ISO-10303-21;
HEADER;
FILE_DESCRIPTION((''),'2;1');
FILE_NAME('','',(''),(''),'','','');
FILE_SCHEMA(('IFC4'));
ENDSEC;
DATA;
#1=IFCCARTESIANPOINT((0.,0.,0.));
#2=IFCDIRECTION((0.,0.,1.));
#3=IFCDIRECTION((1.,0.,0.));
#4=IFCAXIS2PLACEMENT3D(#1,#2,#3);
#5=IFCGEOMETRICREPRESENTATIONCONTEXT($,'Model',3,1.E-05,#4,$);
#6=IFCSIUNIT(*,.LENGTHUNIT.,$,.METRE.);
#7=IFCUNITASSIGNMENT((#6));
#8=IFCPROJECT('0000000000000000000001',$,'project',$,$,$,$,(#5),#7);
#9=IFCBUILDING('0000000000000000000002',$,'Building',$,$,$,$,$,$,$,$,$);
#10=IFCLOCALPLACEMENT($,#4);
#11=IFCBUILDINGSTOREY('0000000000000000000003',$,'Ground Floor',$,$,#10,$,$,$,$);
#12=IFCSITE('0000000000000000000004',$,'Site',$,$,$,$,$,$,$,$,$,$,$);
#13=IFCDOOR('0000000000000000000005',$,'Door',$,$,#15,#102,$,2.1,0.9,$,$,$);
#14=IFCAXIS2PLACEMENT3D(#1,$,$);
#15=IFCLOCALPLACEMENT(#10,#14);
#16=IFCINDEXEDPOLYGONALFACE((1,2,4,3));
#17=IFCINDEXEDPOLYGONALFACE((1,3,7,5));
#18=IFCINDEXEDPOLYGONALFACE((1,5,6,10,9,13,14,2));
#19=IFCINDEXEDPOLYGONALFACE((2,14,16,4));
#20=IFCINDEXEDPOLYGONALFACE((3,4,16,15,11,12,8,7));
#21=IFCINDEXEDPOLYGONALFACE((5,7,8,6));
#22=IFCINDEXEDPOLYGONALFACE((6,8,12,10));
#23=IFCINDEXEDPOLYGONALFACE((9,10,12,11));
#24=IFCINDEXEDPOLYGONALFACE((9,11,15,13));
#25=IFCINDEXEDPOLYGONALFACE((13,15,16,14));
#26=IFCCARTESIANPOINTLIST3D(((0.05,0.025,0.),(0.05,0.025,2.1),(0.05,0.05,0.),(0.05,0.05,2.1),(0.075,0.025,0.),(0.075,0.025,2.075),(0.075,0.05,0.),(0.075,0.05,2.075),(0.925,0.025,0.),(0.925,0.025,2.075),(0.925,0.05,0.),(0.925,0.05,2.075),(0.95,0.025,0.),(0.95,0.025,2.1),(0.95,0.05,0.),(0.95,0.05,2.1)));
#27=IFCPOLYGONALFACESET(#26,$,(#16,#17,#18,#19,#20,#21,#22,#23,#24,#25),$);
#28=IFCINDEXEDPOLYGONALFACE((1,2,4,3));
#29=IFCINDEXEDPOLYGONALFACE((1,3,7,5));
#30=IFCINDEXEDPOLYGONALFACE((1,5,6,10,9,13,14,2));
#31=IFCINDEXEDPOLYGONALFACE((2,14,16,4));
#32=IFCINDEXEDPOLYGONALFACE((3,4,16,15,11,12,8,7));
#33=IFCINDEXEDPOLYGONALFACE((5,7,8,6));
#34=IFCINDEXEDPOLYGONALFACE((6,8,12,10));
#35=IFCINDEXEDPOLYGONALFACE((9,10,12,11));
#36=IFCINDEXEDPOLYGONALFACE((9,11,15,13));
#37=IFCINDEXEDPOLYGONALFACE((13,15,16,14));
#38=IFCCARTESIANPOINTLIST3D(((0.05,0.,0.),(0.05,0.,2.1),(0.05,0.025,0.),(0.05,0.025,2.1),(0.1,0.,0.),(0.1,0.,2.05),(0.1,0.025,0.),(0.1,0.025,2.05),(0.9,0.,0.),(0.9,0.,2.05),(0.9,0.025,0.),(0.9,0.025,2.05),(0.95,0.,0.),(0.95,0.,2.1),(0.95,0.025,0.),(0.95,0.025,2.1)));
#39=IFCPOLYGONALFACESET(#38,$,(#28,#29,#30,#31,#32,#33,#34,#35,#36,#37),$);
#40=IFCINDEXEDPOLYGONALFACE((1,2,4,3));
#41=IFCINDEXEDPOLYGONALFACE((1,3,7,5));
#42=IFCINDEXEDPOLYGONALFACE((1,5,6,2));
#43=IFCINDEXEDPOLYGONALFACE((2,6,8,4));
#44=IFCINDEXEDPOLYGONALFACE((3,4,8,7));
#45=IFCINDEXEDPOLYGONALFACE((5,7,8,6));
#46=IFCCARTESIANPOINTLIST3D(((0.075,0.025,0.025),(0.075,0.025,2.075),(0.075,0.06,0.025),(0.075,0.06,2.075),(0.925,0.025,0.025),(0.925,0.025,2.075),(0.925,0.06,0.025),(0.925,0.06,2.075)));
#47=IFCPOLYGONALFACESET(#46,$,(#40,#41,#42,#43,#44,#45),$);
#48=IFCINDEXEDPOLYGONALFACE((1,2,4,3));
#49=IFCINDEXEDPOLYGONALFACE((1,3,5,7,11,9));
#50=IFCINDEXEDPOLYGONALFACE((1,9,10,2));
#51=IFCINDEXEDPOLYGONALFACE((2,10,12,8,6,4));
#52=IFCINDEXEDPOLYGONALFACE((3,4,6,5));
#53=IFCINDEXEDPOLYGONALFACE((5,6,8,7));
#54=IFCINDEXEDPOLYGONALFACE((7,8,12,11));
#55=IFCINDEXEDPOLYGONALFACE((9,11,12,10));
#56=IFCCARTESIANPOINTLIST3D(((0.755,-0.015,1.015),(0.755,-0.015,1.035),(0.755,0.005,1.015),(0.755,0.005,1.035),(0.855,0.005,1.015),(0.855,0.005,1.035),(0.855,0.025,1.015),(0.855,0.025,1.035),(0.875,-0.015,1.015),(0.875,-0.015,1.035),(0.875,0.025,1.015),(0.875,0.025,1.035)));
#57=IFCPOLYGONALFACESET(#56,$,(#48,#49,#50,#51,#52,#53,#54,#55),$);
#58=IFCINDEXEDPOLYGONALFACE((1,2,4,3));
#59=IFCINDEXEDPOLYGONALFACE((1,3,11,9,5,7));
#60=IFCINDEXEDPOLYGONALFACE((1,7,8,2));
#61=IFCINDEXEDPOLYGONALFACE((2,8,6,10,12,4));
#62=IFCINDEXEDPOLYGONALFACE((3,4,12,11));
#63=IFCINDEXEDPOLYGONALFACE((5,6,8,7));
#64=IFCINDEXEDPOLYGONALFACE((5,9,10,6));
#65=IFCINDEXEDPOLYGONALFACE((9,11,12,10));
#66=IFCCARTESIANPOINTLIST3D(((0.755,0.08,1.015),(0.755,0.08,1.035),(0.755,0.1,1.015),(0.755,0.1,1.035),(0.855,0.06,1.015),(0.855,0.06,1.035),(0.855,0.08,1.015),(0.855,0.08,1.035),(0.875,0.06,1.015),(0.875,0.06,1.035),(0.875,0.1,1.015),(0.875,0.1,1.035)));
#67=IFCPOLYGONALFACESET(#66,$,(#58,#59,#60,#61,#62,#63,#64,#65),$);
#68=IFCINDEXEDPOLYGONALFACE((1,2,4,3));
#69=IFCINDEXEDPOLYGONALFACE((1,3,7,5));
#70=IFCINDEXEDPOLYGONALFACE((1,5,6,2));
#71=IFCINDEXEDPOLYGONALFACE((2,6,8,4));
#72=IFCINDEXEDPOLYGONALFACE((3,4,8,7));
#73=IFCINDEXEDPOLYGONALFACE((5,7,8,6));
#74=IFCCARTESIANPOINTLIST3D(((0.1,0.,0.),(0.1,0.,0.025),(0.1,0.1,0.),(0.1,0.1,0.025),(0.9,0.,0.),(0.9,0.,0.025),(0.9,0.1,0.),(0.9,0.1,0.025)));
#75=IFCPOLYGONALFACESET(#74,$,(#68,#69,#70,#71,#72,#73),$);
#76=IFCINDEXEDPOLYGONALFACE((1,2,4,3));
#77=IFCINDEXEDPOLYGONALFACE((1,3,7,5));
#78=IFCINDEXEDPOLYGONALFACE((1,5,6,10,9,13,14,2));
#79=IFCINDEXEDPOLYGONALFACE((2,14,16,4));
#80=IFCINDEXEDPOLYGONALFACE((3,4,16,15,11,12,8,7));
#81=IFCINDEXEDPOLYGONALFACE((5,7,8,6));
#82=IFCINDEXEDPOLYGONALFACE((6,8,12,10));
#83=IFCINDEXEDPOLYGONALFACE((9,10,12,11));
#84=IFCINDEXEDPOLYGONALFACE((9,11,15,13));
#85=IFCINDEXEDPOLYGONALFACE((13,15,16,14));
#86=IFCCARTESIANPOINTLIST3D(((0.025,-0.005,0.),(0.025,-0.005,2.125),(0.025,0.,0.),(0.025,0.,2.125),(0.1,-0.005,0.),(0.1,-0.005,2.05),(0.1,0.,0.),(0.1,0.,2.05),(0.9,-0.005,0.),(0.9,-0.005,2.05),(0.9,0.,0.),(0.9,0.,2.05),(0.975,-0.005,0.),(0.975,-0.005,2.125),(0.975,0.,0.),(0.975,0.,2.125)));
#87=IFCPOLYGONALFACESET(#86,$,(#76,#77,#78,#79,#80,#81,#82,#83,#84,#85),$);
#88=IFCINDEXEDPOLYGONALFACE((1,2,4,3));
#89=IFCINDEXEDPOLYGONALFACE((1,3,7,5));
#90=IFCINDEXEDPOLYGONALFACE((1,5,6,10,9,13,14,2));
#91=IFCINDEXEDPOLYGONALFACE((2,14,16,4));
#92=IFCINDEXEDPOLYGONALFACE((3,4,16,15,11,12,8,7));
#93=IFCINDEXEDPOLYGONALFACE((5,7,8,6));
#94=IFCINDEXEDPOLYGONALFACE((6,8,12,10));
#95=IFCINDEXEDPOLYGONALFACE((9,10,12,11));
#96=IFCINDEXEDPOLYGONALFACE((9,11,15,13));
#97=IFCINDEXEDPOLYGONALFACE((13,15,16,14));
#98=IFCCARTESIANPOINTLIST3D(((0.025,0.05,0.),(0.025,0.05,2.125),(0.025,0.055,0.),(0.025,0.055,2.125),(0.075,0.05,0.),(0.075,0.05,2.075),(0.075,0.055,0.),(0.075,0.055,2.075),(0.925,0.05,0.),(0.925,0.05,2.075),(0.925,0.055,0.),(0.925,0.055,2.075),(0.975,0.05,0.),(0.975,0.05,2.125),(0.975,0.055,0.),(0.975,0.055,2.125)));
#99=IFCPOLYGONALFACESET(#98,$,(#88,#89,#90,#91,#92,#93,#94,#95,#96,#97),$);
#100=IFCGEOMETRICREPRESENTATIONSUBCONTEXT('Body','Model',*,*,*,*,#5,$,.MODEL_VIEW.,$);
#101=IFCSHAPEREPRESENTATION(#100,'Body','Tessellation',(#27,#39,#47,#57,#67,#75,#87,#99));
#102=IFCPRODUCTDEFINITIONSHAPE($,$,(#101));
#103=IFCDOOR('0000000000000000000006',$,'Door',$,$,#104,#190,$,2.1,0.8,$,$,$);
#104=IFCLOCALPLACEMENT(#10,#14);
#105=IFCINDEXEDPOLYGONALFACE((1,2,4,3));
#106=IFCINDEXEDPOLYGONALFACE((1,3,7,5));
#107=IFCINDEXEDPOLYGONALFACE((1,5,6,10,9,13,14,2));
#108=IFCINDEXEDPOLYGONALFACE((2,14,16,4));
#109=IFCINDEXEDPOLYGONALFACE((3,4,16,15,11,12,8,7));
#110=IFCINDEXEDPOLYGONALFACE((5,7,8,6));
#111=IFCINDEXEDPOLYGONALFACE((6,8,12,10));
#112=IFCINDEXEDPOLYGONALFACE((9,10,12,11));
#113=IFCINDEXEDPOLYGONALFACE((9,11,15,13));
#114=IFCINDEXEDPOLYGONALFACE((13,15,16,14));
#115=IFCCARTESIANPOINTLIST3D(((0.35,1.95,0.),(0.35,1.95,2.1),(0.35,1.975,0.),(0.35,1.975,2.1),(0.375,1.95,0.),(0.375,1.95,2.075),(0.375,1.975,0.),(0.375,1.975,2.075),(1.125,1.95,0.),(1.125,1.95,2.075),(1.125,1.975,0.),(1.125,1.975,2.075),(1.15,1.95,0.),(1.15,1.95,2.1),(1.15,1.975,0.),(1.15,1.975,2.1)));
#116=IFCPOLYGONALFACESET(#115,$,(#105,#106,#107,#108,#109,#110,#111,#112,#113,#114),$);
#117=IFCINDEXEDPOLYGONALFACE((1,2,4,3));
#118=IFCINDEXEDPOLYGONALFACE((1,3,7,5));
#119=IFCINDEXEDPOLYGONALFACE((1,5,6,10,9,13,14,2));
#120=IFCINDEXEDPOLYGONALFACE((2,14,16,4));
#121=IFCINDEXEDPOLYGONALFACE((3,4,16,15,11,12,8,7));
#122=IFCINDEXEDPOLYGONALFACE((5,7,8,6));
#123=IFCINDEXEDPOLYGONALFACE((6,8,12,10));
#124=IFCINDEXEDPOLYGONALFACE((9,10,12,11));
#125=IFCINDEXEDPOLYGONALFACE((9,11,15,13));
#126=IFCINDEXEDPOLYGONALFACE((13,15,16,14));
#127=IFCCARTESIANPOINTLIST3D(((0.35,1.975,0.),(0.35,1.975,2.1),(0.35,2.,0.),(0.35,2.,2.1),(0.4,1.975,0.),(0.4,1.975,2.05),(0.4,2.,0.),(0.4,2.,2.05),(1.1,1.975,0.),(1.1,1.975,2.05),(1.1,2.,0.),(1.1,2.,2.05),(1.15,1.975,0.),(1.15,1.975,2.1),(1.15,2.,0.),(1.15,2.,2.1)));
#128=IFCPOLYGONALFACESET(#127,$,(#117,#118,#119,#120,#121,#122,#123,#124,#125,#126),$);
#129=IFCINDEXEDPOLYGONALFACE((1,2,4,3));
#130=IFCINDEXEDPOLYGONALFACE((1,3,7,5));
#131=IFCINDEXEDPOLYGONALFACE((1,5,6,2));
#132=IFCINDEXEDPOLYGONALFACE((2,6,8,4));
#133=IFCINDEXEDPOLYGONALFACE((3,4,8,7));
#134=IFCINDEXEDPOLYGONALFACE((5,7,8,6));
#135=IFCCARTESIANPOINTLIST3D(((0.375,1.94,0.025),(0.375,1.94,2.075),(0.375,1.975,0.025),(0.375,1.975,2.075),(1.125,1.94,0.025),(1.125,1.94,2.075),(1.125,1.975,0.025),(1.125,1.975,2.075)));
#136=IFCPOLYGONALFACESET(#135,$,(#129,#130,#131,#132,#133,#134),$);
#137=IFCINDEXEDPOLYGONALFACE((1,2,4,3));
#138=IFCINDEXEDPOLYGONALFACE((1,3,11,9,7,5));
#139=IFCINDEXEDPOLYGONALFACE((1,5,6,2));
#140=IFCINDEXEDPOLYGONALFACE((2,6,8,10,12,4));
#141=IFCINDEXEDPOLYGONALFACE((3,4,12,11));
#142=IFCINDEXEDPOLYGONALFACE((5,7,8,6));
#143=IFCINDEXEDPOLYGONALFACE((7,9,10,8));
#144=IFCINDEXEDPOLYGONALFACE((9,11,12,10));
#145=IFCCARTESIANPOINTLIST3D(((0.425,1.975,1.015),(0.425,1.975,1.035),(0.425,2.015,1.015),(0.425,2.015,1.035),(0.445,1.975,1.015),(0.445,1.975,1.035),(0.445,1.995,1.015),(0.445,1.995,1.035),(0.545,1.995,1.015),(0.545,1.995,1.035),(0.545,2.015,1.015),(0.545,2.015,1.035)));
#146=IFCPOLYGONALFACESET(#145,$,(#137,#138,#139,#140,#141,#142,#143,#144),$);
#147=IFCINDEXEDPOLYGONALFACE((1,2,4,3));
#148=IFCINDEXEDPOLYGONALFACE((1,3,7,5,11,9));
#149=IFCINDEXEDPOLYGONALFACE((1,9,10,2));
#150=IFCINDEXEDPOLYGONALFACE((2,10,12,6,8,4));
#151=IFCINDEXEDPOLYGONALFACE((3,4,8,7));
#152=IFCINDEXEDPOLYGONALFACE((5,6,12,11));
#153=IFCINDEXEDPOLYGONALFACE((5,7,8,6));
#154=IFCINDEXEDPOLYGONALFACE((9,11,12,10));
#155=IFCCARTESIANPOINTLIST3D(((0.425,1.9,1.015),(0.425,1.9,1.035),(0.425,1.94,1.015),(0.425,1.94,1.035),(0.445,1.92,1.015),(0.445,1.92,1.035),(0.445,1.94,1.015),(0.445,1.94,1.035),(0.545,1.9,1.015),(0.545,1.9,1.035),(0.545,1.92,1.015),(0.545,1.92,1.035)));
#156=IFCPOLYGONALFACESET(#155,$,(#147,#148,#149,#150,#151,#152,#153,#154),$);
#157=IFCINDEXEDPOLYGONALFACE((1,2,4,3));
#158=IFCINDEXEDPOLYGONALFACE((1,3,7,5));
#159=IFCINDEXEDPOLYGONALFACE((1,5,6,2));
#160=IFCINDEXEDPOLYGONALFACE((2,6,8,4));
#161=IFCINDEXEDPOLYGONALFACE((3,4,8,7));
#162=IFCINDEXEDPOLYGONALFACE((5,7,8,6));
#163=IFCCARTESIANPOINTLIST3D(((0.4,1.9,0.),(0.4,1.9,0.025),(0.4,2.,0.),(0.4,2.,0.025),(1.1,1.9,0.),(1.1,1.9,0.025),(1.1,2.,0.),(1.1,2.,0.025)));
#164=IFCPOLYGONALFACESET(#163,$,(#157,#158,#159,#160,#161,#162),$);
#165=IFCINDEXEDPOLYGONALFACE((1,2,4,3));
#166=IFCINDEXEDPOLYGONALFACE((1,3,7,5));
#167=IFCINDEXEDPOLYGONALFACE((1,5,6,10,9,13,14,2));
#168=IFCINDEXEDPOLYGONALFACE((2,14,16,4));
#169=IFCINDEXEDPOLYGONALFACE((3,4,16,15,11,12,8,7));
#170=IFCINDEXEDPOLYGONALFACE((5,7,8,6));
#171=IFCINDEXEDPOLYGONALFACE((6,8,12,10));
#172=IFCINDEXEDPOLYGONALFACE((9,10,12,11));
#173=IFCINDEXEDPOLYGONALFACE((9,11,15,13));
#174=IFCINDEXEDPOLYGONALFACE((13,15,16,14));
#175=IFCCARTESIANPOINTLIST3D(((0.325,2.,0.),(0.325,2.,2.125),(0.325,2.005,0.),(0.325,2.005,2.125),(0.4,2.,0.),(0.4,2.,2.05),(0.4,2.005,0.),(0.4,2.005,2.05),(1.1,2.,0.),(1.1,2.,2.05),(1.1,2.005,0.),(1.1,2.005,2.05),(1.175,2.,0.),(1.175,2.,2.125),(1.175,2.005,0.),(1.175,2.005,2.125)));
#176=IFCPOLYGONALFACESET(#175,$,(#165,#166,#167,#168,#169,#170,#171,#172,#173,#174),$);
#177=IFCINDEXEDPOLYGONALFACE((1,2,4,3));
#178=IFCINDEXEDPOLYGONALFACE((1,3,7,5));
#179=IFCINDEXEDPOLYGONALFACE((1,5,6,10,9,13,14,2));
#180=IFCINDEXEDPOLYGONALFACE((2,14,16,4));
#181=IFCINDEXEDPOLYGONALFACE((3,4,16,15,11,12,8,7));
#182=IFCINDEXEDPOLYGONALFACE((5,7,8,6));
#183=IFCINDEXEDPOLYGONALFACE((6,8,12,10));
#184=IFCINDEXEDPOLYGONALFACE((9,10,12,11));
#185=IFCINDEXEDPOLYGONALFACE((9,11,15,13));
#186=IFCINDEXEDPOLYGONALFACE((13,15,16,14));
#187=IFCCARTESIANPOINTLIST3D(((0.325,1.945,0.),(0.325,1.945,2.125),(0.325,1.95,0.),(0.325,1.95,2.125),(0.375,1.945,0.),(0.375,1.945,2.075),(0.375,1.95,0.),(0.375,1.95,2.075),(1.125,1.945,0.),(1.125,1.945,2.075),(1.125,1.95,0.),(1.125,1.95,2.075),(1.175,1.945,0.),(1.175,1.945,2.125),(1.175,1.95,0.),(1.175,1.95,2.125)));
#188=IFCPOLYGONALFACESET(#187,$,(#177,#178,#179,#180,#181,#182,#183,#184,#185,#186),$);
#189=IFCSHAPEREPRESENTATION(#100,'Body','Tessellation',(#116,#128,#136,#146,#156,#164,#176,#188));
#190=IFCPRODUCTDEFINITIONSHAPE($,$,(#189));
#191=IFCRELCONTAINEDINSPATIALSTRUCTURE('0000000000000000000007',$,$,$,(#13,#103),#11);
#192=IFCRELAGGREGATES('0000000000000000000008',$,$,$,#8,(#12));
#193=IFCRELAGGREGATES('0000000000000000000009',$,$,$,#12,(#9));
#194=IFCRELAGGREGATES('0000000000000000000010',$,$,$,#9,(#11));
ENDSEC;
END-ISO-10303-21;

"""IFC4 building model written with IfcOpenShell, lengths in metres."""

from ifc_helpers import new_model, si_unit, frame, origin_with_axes, place, context, subcontext, project, spatial, line, indexed_curve, outline, extrude, element, save


model = new_model("IFC4")

# Units and contexts
model_context = context("Model", 3, precision=1e-05, world=origin_with_axes())
body_context = subcontext(model_context, "Body", "Model", "MODEL_VIEW")
ifc_project = project(units=[si_unit("LENGTHUNIT", "METRE")], contexts=[model_context])

# Site, building, storey
site = spatial("IfcSite", under=ifc_project, Name="Site")
building = spatial("IfcBuilding", under=site, Name="Building")
storey_placement = place(None, origin_with_axes())
storey = spatial("IfcBuildingStorey", under=building, at=storey_placement, Name="Ground Floor")

# Doors
door_1_placement = place(storey_placement, frame((0.05, 0.0, 0.0), z_axis=(0.0, 0.0, 1.0), x_axis=(1.0, 0.0, 0.0)))
element("IfcDoor", 1, at=door_1_placement, inside=storey, Name="Door", OverallHeight=2.1, OverallWidth=0.9, context=body_context, shape_type="SweptSolid", body=[
    extrude(outline(indexed_curve([(0.0, 0.0), (0.0, 2.1), (0.9, 2.1), (0.9, 0.0), (0.875, 0.0), (0.875, 2.075), (0.025, 2.075), (0.025, 0.0)], segments=[line(1, 2, 3, 4, 5, 6, 7, 8, 1)])), frame((0.0, 0.025, 0.0), z_axis=(0.0, -1.0, 0.0), x_axis=(1.0, 0.0, 0.0)), (0.0, 0.0, -1.0), 0.025),
    extrude(outline(indexed_curve([(0.0, 0.0), (0.0, 2.1), (0.9, 2.1), (0.9, 0.0), (0.85, 0.0), (0.85, 2.05), (0.05, 2.05), (0.05, 0.0)], segments=[line(1, 2, 3, 4, 5, 6, 7, 8, 1)])), frame((0.0, 0.0, 0.0), z_axis=(0.0, -1.0, 0.0), x_axis=(1.0, 0.0, 0.0)), (0.0, 0.0, -1.0), 0.025),
    extrude(outline(indexed_curve([(0.0, 0.0), (0.85, 0.0), (0.85, 0.035), (0.0, 0.035)], segments=[line(1, 2, 3, 4, 1)])), frame((0.025, 0.025, 0.025), z_axis=(0.0, 0.0, 1.0), x_axis=(1.0, 0.0, 0.0)), (0.0, 0.0, 1.0), 2.05),
    extrude(outline(indexed_curve([(0.0, 0.0), (0.0, -0.04), (-0.12, -0.04), (-0.12, -0.02), (-0.02, -0.02), (-0.02, 0.0)], segments=[line(1, 2, 3, 4, 5, 6, 1)])), frame((0.825, 0.025, 1.015), z_axis=(0.0, 0.0, 1.0), x_axis=(1.0, 0.0, 0.0)), (0.0, 0.0, 1.0), 0.02),
    extrude(outline(indexed_curve([(0.0, 0.0), (0.0, 0.04), (-0.12, 0.04), (-0.12, 0.02), (-0.02, 0.02), (-0.02, 0.0)], segments=[line(1, 2, 3, 4, 5, 6, 1)])), frame((0.825, 0.06, 1.015), z_axis=(0.0, 0.0, 1.0), x_axis=(1.0, 0.0, 0.0)), (0.0, 0.0, 1.0), 0.02),
    extrude(outline(indexed_curve([(0.0, 0.0), (0.8, 0.0), (0.8, 0.1), (0.0, 0.1)], segments=[line(1, 2, 3, 4, 1)])), frame((0.05, 0.0, 0.0), z_axis=(0.0, 0.0, 1.0), x_axis=(1.0, 0.0, 0.0)), (0.0, 0.0, 1.0), 0.025),
    extrude(outline(indexed_curve([(0.0, 0.0), (0.0, 2.125), (0.95, 2.125), (0.95, 0.0), (0.875, 0.0), (0.875, 2.05), (0.075, 2.05), (0.075, 0.0)], segments=[line(1, 2, 3, 4, 5, 6, 7, 8, 1)])), frame((-0.025, -0.005, 0.0), z_axis=(0.0, -1.0, 0.0), x_axis=(1.0, 0.0, 0.0)), (0.0, 0.0, -1.0), 0.005),
    extrude(outline(indexed_curve([(0.0, 0.0), (0.0, 2.125), (0.95, 2.125), (0.95, 0.0), (0.9, 0.0), (0.9, 2.075), (0.05, 2.075), (0.05, 0.0)], segments=[line(1, 2, 3, 4, 5, 6, 7, 8, 1)])), frame((-0.025, 0.05, 0.0), z_axis=(0.0, -1.0, 0.0), x_axis=(1.0, 0.0, 0.0)), (0.0, 0.0, -1.0), 0.005),
])
door_2_placement = place(storey_placement, frame((1.15, 2.0, 0.0), z_axis=(0.0, 0.0, 1.0), x_axis=(-1.0, 0.0, 0.0)))
element("IfcDoor", 2, at=door_2_placement, inside=storey, Name="Door", OverallHeight=2.1, OverallWidth=0.8, context=body_context, shape_type="SweptSolid", body=[
    extrude(outline(indexed_curve([(0.0, 0.0), (0.0, 2.1), (0.8, 2.1), (0.8, 0.0), (0.775, 0.0), (0.775, 2.075), (0.025, 2.075), (0.025, 0.0)], segments=[line(1, 2, 3, 4, 5, 6, 7, 8, 1)])), frame((0.0, 0.025, 0.0), z_axis=(0.0, -1.0, 0.0), x_axis=(1.0, 0.0, 0.0)), (0.0, 0.0, -1.0), 0.025),
    extrude(outline(indexed_curve([(0.0, 0.0), (0.0, 2.1), (0.8, 2.1), (0.8, 0.0), (0.75, 0.0), (0.75, 2.05), (0.05, 2.05), (0.05, 0.0)], segments=[line(1, 2, 3, 4, 5, 6, 7, 8, 1)])), frame((0.0, 0.0, 0.0), z_axis=(0.0, -1.0, 0.0), x_axis=(1.0, 0.0, 0.0)), (0.0, 0.0, -1.0), 0.025),
    extrude(outline(indexed_curve([(0.0, 0.0), (0.75, 0.0), (0.75, 0.035), (0.0, 0.035)], segments=[line(1, 2, 3, 4, 1)])), frame((0.025, 0.025, 0.025), z_axis=(0.0, 0.0, 1.0), x_axis=(1.0, 0.0, 0.0)), (0.0, 0.0, 1.0), 2.05),
    extrude(outline(indexed_curve([(0.0, 0.0), (0.0, -0.04), (-0.12, -0.04), (-0.12, -0.02), (-0.02, -0.02), (-0.02, 0.0)], segments=[line(1, 2, 3, 4, 5, 6, 1)])), frame((0.725, 0.025, 1.015), z_axis=(0.0, 0.0, 1.0), x_axis=(1.0, 0.0, 0.0)), (0.0, 0.0, 1.0), 0.02),
    extrude(outline(indexed_curve([(0.0, 0.0), (0.0, 0.04), (-0.12, 0.04), (-0.12, 0.02), (-0.02, 0.02), (-0.02, 0.0)], segments=[line(1, 2, 3, 4, 5, 6, 1)])), frame((0.725, 0.06, 1.015), z_axis=(0.0, 0.0, 1.0), x_axis=(1.0, 0.0, 0.0)), (0.0, 0.0, 1.0), 0.02),
    extrude(outline(indexed_curve([(0.0, 0.0), (0.7, 0.0), (0.7, 0.1), (0.0, 0.1)], segments=[line(1, 2, 3, 4, 1)])), frame((0.05, 0.0, 0.0), z_axis=(0.0, 0.0, 1.0), x_axis=(1.0, 0.0, 0.0)), (0.0, 0.0, 1.0), 0.025),
    extrude(outline(indexed_curve([(0.0, 0.0), (0.0, 2.125), (0.85, 2.125), (0.85, 0.0), (0.775, 0.0), (0.775, 2.05), (0.075, 2.05), (0.075, 0.0)], segments=[line(1, 2, 3, 4, 5, 6, 7, 8, 1)])), frame((-0.025, -0.005, 0.0), z_axis=(0.0, -1.0, 0.0), x_axis=(1.0, 0.0, 0.0)), (0.0, 0.0, -1.0), 0.005),
    extrude(outline(indexed_curve([(0.0, 0.0), (0.0, 2.125), (0.85, 2.125), (0.85, 0.0), (0.8, 0.0), (0.8, 2.075), (0.05, 2.075), (0.05, 0.0)], segments=[line(1, 2, 3, 4, 5, 6, 7, 8, 1)])), frame((-0.025, 0.05, 0.0), z_axis=(0.0, -1.0, 0.0), x_axis=(1.0, 0.0, 0.0)), (0.0, 0.0, -1.0), 0.005),
])

save(model, "model.ifc")
